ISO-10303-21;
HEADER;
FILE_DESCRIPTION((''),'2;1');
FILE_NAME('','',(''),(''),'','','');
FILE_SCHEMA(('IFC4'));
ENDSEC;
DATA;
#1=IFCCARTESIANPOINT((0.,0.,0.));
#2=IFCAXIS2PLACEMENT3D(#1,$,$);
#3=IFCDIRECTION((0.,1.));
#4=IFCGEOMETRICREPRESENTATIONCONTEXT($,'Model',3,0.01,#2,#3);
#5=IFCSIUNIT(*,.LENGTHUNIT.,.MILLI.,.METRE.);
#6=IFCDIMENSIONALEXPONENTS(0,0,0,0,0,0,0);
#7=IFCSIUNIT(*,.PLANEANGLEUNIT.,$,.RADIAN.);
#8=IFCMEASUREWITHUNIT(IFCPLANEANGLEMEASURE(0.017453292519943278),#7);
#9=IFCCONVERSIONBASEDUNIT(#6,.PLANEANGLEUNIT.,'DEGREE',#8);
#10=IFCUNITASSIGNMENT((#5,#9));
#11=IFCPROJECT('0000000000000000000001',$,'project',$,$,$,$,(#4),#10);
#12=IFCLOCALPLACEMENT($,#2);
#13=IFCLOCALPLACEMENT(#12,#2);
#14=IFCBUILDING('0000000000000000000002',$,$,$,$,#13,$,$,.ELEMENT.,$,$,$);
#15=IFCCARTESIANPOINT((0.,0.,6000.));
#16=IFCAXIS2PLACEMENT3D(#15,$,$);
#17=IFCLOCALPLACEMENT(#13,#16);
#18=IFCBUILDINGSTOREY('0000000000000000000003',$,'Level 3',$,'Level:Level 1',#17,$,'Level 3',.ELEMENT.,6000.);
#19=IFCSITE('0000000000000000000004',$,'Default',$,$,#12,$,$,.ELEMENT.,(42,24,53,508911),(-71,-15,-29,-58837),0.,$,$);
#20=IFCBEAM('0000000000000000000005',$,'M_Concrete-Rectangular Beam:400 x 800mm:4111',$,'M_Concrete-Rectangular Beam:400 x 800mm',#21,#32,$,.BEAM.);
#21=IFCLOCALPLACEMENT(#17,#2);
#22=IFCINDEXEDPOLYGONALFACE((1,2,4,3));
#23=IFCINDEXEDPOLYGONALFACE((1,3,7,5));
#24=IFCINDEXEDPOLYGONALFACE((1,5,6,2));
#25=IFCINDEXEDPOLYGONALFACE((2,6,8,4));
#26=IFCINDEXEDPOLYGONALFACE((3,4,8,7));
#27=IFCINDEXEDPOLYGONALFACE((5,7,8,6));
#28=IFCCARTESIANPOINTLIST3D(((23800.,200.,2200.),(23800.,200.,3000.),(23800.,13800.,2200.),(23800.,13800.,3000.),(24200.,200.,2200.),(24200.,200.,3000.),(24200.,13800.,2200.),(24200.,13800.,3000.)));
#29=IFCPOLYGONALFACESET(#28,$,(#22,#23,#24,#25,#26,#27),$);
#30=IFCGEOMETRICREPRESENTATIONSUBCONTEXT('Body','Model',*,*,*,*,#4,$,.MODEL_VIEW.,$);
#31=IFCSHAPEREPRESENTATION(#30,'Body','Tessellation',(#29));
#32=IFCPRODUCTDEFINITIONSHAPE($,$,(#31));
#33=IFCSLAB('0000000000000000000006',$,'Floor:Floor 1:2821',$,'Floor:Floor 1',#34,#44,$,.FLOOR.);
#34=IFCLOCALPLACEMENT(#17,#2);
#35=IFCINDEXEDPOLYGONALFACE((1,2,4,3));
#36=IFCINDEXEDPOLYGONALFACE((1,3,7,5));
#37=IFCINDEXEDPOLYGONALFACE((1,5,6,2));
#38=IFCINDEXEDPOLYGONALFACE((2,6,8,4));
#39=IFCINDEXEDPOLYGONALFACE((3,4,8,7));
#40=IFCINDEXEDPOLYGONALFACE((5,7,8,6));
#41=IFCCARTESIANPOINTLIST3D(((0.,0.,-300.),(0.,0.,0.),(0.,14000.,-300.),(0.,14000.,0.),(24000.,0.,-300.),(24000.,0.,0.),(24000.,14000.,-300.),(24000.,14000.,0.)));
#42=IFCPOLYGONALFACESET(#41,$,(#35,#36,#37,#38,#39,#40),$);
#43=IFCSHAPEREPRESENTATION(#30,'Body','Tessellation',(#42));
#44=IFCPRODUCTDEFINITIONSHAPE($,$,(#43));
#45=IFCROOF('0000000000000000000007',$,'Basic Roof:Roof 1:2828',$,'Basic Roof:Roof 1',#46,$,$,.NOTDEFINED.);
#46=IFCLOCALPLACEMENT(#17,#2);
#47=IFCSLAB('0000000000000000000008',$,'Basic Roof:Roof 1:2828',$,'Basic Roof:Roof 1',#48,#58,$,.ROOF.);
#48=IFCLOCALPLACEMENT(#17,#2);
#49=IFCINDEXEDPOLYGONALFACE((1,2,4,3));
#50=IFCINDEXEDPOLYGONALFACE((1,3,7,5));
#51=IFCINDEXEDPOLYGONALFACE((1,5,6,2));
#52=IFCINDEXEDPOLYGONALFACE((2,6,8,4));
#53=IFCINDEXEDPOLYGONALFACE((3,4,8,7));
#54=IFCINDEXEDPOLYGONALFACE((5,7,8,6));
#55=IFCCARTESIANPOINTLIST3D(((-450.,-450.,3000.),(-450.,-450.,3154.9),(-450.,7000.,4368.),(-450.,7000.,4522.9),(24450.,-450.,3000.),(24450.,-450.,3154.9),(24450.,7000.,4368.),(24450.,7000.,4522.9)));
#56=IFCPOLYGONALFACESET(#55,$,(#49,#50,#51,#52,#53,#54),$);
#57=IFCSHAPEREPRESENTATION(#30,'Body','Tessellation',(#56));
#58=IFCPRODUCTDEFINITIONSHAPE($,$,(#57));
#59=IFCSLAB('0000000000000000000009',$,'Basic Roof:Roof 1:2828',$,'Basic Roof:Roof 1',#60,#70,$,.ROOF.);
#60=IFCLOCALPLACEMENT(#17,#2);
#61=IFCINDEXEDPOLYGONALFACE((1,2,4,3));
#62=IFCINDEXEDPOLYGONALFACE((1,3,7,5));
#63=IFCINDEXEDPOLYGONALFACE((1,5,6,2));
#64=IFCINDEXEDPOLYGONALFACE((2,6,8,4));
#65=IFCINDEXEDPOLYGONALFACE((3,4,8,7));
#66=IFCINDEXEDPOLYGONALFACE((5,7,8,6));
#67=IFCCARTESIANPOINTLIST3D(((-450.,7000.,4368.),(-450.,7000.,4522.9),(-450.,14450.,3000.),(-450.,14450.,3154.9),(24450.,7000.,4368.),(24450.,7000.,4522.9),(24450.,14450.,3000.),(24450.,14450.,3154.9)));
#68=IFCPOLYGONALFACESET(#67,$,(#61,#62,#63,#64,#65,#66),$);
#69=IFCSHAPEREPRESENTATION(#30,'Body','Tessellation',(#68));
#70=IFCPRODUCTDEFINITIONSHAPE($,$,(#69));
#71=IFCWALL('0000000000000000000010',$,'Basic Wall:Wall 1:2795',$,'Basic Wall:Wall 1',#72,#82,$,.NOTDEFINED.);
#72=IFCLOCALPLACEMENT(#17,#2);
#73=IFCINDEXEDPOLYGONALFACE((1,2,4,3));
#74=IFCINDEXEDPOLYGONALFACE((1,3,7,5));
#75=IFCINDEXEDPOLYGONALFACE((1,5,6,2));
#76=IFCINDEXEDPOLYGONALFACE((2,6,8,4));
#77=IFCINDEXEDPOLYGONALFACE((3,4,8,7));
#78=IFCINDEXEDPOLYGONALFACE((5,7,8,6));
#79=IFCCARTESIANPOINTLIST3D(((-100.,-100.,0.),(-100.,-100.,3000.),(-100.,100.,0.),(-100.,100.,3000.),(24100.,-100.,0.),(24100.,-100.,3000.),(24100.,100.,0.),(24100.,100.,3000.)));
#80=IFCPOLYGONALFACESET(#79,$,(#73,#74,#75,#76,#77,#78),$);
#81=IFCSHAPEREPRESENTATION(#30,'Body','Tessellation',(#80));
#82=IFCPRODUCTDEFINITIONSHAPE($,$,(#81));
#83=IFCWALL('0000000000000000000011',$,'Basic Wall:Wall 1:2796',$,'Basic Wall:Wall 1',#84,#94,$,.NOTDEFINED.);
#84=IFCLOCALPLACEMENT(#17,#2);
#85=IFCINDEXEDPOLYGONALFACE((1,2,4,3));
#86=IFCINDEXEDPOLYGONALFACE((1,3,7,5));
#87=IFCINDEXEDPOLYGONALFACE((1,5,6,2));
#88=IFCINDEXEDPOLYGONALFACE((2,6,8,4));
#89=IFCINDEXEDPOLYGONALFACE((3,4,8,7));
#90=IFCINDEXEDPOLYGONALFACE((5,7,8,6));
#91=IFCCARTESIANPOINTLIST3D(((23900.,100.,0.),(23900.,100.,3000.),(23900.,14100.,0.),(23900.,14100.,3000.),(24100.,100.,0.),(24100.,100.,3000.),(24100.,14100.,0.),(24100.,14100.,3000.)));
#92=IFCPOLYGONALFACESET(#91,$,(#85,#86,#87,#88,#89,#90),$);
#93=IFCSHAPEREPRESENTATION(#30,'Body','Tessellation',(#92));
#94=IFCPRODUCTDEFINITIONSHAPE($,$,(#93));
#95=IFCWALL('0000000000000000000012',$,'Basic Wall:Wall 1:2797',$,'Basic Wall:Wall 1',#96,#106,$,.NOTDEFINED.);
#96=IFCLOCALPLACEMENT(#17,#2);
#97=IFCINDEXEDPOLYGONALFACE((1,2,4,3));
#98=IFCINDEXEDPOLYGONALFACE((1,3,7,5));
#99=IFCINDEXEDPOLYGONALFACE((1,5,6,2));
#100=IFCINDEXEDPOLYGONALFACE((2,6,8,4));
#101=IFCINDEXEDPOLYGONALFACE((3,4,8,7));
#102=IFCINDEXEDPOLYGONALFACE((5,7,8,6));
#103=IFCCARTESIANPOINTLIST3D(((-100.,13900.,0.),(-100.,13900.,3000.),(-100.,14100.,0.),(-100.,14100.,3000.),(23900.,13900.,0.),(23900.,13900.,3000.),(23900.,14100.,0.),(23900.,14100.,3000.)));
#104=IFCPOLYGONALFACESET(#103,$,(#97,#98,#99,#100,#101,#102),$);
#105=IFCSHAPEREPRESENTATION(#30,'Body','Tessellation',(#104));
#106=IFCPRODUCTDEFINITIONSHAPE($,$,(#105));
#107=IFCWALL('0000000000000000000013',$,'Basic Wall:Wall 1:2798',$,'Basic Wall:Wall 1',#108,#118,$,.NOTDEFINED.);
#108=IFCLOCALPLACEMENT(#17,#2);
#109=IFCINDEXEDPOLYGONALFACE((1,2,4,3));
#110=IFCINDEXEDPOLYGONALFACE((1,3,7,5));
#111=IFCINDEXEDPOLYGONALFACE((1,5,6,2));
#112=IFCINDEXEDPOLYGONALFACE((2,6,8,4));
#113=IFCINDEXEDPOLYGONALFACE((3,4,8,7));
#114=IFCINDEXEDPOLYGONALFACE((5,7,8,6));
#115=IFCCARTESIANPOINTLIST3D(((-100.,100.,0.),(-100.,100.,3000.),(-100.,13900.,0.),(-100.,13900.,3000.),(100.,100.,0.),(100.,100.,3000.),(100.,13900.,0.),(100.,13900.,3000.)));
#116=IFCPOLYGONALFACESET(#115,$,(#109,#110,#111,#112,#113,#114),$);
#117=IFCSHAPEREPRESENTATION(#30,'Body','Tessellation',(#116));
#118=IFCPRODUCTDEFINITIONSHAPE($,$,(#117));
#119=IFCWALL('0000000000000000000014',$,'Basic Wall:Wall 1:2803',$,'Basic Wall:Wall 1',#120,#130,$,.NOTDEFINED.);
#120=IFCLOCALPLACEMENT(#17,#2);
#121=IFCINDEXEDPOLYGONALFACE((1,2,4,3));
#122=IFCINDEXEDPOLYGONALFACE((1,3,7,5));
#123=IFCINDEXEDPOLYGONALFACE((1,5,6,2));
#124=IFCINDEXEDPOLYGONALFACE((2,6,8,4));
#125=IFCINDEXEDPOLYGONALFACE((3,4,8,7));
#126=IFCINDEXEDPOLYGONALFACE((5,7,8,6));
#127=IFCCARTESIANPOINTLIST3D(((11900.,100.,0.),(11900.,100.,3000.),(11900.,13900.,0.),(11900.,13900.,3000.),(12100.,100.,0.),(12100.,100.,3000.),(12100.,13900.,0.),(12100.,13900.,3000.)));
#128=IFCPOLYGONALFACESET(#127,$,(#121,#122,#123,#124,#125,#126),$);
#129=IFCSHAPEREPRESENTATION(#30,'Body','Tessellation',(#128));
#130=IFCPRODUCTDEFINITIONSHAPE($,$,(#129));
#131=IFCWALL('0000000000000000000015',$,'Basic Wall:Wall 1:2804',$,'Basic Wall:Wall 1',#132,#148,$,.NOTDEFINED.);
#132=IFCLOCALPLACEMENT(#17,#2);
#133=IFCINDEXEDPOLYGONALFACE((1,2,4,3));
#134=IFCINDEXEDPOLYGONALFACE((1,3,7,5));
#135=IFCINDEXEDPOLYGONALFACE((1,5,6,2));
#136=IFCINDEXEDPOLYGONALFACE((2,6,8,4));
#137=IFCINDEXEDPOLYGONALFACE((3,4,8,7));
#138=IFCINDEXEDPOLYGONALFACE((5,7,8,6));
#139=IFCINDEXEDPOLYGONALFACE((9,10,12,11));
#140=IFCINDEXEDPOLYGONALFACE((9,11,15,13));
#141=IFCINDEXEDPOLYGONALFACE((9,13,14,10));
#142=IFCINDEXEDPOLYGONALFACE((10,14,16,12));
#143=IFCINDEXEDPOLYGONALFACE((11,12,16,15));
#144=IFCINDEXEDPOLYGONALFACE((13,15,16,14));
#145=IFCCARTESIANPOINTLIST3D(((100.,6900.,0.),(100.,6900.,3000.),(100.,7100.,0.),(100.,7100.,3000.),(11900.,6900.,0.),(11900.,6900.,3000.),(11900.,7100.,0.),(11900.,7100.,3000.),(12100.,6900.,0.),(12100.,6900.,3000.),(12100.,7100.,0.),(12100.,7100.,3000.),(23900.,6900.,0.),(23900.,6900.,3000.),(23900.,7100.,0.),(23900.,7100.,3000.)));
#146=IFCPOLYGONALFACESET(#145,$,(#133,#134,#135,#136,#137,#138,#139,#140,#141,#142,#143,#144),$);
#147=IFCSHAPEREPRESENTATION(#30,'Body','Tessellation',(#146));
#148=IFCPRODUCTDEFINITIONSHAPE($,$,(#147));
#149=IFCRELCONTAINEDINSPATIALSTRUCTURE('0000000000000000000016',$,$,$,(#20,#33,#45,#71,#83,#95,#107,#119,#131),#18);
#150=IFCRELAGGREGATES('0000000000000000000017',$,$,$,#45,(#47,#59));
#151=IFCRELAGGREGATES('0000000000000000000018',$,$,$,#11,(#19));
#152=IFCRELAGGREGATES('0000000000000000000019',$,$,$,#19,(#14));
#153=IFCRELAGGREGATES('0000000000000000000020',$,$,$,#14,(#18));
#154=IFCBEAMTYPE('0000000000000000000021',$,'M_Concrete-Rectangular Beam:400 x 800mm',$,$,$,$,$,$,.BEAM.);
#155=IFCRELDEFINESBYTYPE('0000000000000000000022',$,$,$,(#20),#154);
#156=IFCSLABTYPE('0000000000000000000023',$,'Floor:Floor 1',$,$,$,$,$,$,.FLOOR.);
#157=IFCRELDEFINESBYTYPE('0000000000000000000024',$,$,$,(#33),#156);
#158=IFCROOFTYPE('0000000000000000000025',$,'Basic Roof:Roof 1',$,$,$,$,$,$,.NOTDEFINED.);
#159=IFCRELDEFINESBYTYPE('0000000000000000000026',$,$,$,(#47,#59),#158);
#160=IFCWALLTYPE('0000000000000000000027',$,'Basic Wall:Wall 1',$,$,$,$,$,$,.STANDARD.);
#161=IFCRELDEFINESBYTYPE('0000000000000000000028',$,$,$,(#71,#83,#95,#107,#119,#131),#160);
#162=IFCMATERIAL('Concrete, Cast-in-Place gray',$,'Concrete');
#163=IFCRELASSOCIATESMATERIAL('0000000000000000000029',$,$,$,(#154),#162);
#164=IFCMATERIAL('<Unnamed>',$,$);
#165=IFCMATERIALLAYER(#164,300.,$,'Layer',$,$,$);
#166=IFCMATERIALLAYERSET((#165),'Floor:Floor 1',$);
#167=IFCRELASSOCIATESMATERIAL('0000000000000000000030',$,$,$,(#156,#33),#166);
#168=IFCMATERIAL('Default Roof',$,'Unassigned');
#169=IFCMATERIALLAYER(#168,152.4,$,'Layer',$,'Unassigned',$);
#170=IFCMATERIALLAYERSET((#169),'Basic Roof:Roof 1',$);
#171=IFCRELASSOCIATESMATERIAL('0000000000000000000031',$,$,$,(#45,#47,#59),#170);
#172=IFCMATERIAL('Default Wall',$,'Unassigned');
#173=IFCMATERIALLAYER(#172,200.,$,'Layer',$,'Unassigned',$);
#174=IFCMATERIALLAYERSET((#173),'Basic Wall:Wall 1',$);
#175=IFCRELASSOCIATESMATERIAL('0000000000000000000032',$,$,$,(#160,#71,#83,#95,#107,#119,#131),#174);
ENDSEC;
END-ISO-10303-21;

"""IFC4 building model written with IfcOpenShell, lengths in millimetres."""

from ifc_helpers import new_model, entity, si_unit, converted_unit, direction, frame, frame_2d, origin, origin_2d_with_axis, place, context, subcontext, project, spatial, rectangle, extrude, source, transform, mapped, material, layer, layer_set, layer_usage, material_profile, profile_set, type_object, type_shapes, element, aggregate, save


model = new_model("IFC4")

# Units and contexts
model_context = context("Model", 3, precision=0.01, world=origin(), true_north=direction((0.0, 1.0)))
body_context = subcontext(model_context, "Body", "Model", "MODEL_VIEW")
ifc_project = project(units=[si_unit("LENGTHUNIT", "METRE", prefix="MILLI"), converted_unit("PLANEANGLEUNIT", "DEGREE", entity("IfcPlaneAngleMeasure", 0.017453292519943278), si_unit("PLANEANGLEUNIT", "RADIAN"), dimensions=[0, 0, 0, 0, 0, 0, 0])], contexts=[model_context])

# Site, building, storey
site_placement = place(None, origin())
site = spatial("IfcSite", under=ifc_project, at=site_placement, Name="Default", CompositionType="ELEMENT", RefLatitude=(42, 24, 53, 508911), RefLongitude=(-71, -15, -29, -58837), RefElevation=0.0)
building_placement = place(site_placement, origin())
building = spatial("IfcBuilding", under=site, at=building_placement, CompositionType="ELEMENT")
storey_placement = place(building_placement, frame((0.0, 0.0, 6000.0)))
storey = spatial("IfcBuildingStorey", under=building, at=storey_placement, Name="Level 3", ObjectType="Level:Level 1", LongName="Level 3", CompositionType="ELEMENT", Elevation=6000.0)

# Beam
ifc_material_1 = material(Name="Concrete, Cast-in-Place gray", Category="Concrete")
ifc_material_profile = material_profile(ifc_material_1, rectangle(XDim=800.0, YDim=400.0, at=origin_2d_with_axis()), Name="400 x 800mm")
ifc_profile_set = profile_set([ifc_material_profile], Name="400 x 800mm")
beam_type_1 = type_object("IfcBeamType", Name="M_Concrete-Rectangular Beam:400 x 800mm", PredefinedType="BEAM", material=ifc_profile_set)
shared_shape_1 = source(origin(), body_context, "Body", "SweptSolid", [
    extrude(rectangle(XDim=800.0, YDim=400.0, at=frame_2d((0.0, 0.0), x_axis=(0.0, 1.0))), frame((24000.0, 200.0, 8600.0), z_axis=(0.0, 1.0, 0.0), x_axis=(-1.0, 0.0, 0.0)), (0.0, 0.0, 1.0), 13600.0),
])
type_shapes(beam_type_1, [shared_shape_1])
beam_1_placement = place(storey_placement, frame((0.0, 0.0, -6000.0)))
element("IfcBeam", 1, at=beam_1_placement, inside=storey, type_object=beam_type_1, Name="M_Concrete-Rectangular Beam:400 x 800mm:4111", ObjectType="M_Concrete-Rectangular Beam:400 x 800mm", PredefinedType="BEAM", context=body_context, shape_type="MappedRepresentation", body=[
    mapped(shared_shape_1, transform((0.0, 0.0, 0.0), scale=1.0)),
])

# Slab
ifc_material_2 = material(Name="<Unnamed>")
ifc_layer_1 = layer(ifc_material_2, 300.0, Name="Layer")
ifc_layer_set_1 = layer_set([ifc_layer_1], Name="Floor:Floor 1")
ifc_layer_usage_1 = layer_usage(ifc_layer_set_1, "AXIS3", "POSITIVE", 0.0)
slab_type = type_object("IfcSlabType", Name="Floor:Floor 1", PredefinedType="FLOOR", material=ifc_layer_set_1)
slab_1_placement = place(storey_placement, origin())
element("IfcSlab", 2, at=slab_1_placement, inside=storey, type_object=slab_type, material=ifc_layer_usage_1, Name="Floor:Floor 1:2821", ObjectType="Floor:Floor 1", PredefinedType="FLOOR", context=body_context, shape_type="SweptSolid", body=[
    extrude(rectangle(XDim=14000.0, YDim=24000.0, at=origin_2d_with_axis()), frame((12000.0, 7000.0, 0.0), z_axis=(0.0, 0.0, -1.0), x_axis=(0.0, 1.0, 0.0)), (0.0, 0.0, 1.0), 300.0),
])

# Roof, slabs
ifc_material_3 = material(Name="Default Roof", Category="Unassigned")
ifc_layer_2 = layer(ifc_material_3, 152.4, Name="Layer", Category="Unassigned")
ifc_layer_set_2 = layer_set([ifc_layer_2], Name="Basic Roof:Roof 1")
roof_placement = place(storey_placement, frame((-450.0, -450.0, 3000.0)))
roof = element("IfcRoof", 3, at=roof_placement, inside=storey, material=ifc_layer_set_2, Name="Basic Roof:Roof 1:2828", ObjectType="Basic Roof:Roof 1", PredefinedType="NOTDEFINED")
roof_type = type_object("IfcRoofType", Name="Basic Roof:Roof 1", PredefinedType="NOTDEFINED")
slab_2_placement = place(roof_placement, origin())
slab_2 = element("IfcSlab", 4, at=slab_2_placement, type_object=roof_type, material=ifc_layer_set_2, Name="Basic Roof:Roof 1:2828", ObjectType="Basic Roof:Roof 1", PredefinedType="ROOF", context=body_context, shape_type="SweptSolid", body=[
    extrude(rectangle(XDim=24900.0, YDim=7574.6, at=frame_2d((0.0, 0.0), x_axis=(-1.0, 0.0))), frame((12450.0, 3725.0, 684.0), z_axis=(0.0, -0.180603, 0.983556), x_axis=(1.0, 0.0, 0.0)), (0.0, 0.180603, 0.983556), 154.9),
])
slab_3_placement = place(roof_placement, origin())
slab_3 = element("IfcSlab", 5, at=slab_3_placement, type_object=roof_type, material=ifc_layer_set_2, Name="Basic Roof:Roof 1:2828", ObjectType="Basic Roof:Roof 1", PredefinedType="ROOF", context=body_context, shape_type="SweptSolid", body=[
    extrude(rectangle(XDim=7574.6, YDim=24900.0, at=frame_2d((0.0, 0.0), x_axis=(0.0, -1.0))), frame((12450.0, 11175.0, 684.0), z_axis=(0.0, 0.180603, 0.983556), x_axis=(1.0, 0.0, 0.0)), (0.0, -0.180603, 0.983556), 154.9),
])
aggregate(roof, [slab_2, slab_3])

# Walls
ifc_material_4 = material(Name="Default Wall", Category="Unassigned")
ifc_layer_3 = layer(ifc_material_4, 200.0, Name="Layer", Category="Unassigned")
ifc_layer_set_3 = layer_set([ifc_layer_3], Name="Basic Wall:Wall 1")
ifc_layer_usage_2 = layer_usage(ifc_layer_set_3, "AXIS2", "NEGATIVE", 100.0)
wall_type = type_object("IfcWallType", Name="Basic Wall:Wall 1", PredefinedType="STANDARD", material=ifc_layer_set_3)
wall_1_placement = place(storey_placement, frame((-100.0, 0.0, 0.0)))
element("IfcWall", 6, at=wall_1_placement, inside=storey, type_object=wall_type, material=ifc_layer_usage_2, Name="Basic Wall:Wall 1:2795", ObjectType="Basic Wall:Wall 1", PredefinedType="NOTDEFINED", context=body_context, shape_type="SweptSolid", body=[
    extrude(rectangle(XDim=24200.0, YDim=200.0, at=frame_2d((12100.0, 0.0), x_axis=(-1.0, 0.0))), origin(), (0.0, 0.0, 1.0), 3000.0),
])
ifc_layer_usage_3 = layer_usage(ifc_layer_set_3, "AXIS2", "NEGATIVE", 100.0)
wall_2_placement = place(storey_placement, frame((24000.0, 100.0, 0.0), z_axis=(0.0, 0.0, 1.0), x_axis=(0.0, 1.0, 0.0)))
element("IfcWall", 7, at=wall_2_placement, inside=storey, type_object=wall_type, material=ifc_layer_usage_3, Name="Basic Wall:Wall 1:2796", ObjectType="Basic Wall:Wall 1", PredefinedType="NOTDEFINED", context=body_context, shape_type="SweptSolid", body=[
    extrude(rectangle(XDim=14000.0, YDim=200.0, at=frame_2d((7000.0, 0.0), x_axis=(-1.0, 0.0))), origin(), (0.0, 0.0, 1.0), 3000.0),
])
ifc_layer_usage_4 = layer_usage(ifc_layer_set_3, "AXIS2", "NEGATIVE", 100.0)
wall_3_placement = place(storey_placement, frame((23900.0, 14000.0, 0.0), z_axis=(0.0, 0.0, 1.0), x_axis=(-1.0, 0.0, 0.0)))
element("IfcWall", 8, at=wall_3_placement, inside=storey, type_object=wall_type, material=ifc_layer_usage_4, Name="Basic Wall:Wall 1:2797", ObjectType="Basic Wall:Wall 1", PredefinedType="NOTDEFINED", context=body_context, shape_type="SweptSolid", body=[
    extrude(rectangle(XDim=24000.0, YDim=200.0, at=frame_2d((12000.0, 0.0), x_axis=(-1.0, 0.0))), origin(), (0.0, 0.0, 1.0), 3000.0),
])
ifc_layer_usage_5 = layer_usage(ifc_layer_set_3, "AXIS2", "NEGATIVE", 100.0)
wall_4_placement = place(storey_placement, frame((0.0, 13900.0, 0.0), z_axis=(0.0, 0.0, 1.0), x_axis=(0.0, -1.0, 0.0)))
element("IfcWall", 9, at=wall_4_placement, inside=storey, type_object=wall_type, material=ifc_layer_usage_5, Name="Basic Wall:Wall 1:2798", ObjectType="Basic Wall:Wall 1", PredefinedType="NOTDEFINED", context=body_context, shape_type="SweptSolid", body=[
    extrude(rectangle(XDim=13800.0, YDim=200.0, at=frame_2d((6900.0, 0.0), x_axis=(-1.0, 0.0))), origin(), (0.0, 0.0, 1.0), 3000.0),
])
ifc_layer_usage_6 = layer_usage(ifc_layer_set_3, "AXIS2", "NEGATIVE", 100.0)
wall_5_placement = place(storey_placement, frame((12000.0, 100.0, 0.0), z_axis=(0.0, 0.0, 1.0), x_axis=(0.0, 1.0, 0.0)))
element("IfcWall", 10, at=wall_5_placement, inside=storey, type_object=wall_type, material=ifc_layer_usage_6, Name="Basic Wall:Wall 1:2803", ObjectType="Basic Wall:Wall 1", PredefinedType="NOTDEFINED", context=body_context, shape_type="SweptSolid", body=[
    extrude(rectangle(XDim=13800.0, YDim=200.0, at=frame_2d((6900.0, 0.0), x_axis=(-1.0, 0.0))), origin(), (0.0, 0.0, 1.0), 3000.0),
])

# Wall, opening
ifc_layer_usage_7 = layer_usage(ifc_layer_set_3, "AXIS2", "NEGATIVE", 100.0)
wall_6_placement = place(storey_placement, frame((100.0, 7000.0, 0.0)))
wall_6 = element("IfcWall", 11, at=wall_6_placement, inside=storey, type_object=wall_type, material=ifc_layer_usage_7, Name="Basic Wall:Wall 1:2804", ObjectType="Basic Wall:Wall 1", PredefinedType="NOTDEFINED", context=body_context, shape_type="SweptSolid", body=[
    extrude(rectangle(XDim=23800.0, YDim=200.0, at=frame_2d((11900.0, 0.0), x_axis=(-1.0, 0.0))), origin(), (0.0, 0.0, 1.0), 3000.0),
])
opening_placement = place(storey_placement, frame((100.0, 7000.0, 0.0)))
element("IfcOpeningElement", 12, at=opening_placement, cuts=wall_6, PredefinedType="OPENING", context=body_context, shape_type="SweptSolid", body=[
    extrude(rectangle(XDim=3000.0, YDim=200.0, at=frame_2d((0.0, 0.0), x_axis=(1.0, 0.0))), frame((11800.0, 0.0, 1500.0), z_axis=(1.0, 0.0, 0.0), x_axis=(0.0, 0.0, -1.0)), (0.0, 0.0, 1.0), 200.0),
])

save(model, "model.ifc")
